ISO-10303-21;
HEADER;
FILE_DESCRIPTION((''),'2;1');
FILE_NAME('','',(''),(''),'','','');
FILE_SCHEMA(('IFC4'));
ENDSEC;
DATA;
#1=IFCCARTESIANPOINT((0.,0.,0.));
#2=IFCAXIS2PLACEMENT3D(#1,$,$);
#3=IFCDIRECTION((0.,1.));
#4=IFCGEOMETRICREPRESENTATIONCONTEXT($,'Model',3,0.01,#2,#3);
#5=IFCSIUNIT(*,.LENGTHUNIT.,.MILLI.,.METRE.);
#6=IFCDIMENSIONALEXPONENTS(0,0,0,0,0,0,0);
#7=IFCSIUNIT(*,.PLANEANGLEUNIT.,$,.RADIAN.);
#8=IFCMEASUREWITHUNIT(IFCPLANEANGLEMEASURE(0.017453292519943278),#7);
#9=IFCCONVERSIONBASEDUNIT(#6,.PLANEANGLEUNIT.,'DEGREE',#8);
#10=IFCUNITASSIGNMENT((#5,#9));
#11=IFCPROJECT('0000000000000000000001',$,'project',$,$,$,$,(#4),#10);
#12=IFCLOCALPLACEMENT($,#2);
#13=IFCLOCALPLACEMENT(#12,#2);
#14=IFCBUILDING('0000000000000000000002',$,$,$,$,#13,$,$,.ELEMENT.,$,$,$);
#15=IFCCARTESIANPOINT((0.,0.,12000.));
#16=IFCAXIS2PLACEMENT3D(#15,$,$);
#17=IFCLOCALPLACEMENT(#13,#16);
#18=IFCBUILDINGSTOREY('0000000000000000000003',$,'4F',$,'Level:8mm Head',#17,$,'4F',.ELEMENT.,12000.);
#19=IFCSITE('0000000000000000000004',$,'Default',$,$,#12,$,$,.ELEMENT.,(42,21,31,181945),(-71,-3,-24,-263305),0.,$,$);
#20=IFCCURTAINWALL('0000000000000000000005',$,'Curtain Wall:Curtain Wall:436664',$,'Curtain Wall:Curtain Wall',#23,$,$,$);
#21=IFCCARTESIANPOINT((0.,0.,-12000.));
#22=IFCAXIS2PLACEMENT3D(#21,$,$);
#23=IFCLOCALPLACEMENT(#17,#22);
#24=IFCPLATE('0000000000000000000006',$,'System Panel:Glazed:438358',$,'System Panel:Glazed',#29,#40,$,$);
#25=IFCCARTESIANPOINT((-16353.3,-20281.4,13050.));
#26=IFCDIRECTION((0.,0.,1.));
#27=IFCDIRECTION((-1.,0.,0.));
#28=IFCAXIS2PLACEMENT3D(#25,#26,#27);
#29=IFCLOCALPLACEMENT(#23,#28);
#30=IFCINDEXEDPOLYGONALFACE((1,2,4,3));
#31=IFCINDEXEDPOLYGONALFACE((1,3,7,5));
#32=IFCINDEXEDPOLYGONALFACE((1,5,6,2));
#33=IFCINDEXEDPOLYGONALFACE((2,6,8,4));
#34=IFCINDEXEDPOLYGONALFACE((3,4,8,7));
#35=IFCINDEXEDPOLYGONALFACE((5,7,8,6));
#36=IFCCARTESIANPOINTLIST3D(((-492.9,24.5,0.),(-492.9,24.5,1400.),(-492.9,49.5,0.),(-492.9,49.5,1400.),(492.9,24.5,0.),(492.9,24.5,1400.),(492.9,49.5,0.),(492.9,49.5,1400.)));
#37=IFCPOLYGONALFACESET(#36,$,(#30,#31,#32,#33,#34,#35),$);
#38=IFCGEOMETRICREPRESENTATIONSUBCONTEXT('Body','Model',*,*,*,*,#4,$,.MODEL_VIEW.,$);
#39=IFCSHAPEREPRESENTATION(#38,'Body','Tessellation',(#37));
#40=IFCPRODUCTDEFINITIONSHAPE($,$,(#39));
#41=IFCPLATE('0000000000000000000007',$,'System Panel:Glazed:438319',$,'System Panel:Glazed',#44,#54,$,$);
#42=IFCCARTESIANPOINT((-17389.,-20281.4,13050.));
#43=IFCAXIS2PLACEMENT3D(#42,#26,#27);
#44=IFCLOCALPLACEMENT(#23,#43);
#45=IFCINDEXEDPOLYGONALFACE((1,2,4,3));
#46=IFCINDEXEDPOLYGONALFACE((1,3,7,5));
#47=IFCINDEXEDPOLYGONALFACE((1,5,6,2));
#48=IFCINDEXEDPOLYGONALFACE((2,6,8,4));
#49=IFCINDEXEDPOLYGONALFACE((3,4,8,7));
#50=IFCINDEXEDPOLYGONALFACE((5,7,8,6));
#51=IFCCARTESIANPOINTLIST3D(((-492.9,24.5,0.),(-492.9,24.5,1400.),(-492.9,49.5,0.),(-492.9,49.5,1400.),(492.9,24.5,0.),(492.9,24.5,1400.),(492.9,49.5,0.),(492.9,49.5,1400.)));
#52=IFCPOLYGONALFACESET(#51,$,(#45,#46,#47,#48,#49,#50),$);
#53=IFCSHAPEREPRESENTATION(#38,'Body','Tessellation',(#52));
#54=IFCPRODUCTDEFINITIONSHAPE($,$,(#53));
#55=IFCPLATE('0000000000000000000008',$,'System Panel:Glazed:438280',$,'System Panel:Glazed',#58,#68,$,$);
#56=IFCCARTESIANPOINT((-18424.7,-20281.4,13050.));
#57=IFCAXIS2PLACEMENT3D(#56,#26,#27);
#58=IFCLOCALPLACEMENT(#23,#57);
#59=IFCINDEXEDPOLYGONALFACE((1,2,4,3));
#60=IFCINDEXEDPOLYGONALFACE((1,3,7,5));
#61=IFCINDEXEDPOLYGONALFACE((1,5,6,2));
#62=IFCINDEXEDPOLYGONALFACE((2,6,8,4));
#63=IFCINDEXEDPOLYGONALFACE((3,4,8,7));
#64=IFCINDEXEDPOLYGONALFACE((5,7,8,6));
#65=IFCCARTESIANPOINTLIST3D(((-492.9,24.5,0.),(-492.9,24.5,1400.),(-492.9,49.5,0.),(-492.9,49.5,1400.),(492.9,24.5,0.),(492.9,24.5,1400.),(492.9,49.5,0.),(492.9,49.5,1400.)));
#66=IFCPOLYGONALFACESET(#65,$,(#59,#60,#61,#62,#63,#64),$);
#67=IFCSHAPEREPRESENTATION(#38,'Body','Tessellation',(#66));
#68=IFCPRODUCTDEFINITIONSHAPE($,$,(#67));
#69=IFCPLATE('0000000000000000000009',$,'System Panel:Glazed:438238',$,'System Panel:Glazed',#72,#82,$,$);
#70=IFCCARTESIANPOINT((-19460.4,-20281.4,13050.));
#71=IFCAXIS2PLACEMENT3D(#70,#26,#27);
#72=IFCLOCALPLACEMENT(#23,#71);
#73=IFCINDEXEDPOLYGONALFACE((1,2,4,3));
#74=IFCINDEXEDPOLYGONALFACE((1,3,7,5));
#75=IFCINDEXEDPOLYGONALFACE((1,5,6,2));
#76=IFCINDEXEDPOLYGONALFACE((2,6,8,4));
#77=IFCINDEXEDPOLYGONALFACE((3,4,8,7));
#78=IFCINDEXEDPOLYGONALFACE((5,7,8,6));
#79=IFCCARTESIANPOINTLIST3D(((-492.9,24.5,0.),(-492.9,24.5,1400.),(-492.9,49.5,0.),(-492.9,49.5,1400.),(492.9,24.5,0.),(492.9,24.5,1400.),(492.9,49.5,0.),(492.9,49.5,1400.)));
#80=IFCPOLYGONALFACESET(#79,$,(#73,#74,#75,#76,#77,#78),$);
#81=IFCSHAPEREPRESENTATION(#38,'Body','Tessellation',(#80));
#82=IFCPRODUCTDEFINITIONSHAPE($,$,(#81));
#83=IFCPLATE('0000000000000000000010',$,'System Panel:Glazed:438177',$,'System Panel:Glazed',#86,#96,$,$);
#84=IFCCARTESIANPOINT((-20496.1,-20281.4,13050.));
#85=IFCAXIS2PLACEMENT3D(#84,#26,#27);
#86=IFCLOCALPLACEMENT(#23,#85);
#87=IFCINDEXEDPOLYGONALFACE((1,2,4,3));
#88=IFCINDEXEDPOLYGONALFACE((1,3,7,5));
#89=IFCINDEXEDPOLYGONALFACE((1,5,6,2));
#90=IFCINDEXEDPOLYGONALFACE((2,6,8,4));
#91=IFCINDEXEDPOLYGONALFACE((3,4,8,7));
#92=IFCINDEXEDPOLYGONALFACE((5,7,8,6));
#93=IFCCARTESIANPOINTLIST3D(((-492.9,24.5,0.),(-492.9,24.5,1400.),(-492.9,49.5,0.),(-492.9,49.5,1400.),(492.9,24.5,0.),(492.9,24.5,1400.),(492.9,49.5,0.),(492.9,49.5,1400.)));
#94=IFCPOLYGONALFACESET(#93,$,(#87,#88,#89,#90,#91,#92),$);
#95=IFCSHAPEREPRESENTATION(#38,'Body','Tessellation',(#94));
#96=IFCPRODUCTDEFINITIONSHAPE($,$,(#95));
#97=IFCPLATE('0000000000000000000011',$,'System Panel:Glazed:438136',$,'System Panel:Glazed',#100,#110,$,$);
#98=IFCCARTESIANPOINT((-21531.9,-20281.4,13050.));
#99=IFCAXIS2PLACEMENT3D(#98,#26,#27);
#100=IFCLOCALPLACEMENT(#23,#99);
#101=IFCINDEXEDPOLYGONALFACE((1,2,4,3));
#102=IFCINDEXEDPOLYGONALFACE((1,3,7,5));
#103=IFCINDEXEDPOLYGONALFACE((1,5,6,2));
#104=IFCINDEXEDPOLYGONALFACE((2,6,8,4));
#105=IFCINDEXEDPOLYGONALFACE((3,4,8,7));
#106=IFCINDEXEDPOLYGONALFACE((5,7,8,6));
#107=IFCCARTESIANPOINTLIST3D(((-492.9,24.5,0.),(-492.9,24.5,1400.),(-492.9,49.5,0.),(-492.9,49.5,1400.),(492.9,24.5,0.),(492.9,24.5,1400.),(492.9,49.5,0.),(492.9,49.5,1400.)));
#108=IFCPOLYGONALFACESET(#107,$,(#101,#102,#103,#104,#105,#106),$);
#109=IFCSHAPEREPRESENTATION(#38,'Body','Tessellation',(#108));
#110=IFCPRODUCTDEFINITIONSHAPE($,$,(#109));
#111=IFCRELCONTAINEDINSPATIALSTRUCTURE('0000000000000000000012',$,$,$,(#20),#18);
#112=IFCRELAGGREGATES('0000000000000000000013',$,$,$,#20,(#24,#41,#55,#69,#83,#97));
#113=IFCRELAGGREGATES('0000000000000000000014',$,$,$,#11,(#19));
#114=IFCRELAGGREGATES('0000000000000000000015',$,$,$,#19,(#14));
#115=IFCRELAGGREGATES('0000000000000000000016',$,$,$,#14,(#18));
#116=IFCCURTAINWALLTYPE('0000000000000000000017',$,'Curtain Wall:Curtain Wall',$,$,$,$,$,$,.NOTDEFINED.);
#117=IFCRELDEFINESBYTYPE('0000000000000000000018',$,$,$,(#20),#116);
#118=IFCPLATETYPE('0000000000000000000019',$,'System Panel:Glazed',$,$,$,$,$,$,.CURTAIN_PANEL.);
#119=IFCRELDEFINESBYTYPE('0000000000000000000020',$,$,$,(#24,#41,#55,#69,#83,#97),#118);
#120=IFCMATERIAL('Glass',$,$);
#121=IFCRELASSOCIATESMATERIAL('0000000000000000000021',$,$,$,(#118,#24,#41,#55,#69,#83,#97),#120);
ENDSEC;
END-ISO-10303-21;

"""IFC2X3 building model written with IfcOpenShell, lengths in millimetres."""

from ifc_helpers import new_model, entity, si_unit, converted_unit, direction, frame, origin, origin_2d_with_axis, place, context, subcontext, project, spatial, rectangle, extrude, source, transform, mapped, material, type_object, type_shapes, element, aggregate, save


model = new_model("IFC2X3")

# Units and contexts
model_context = context("Model", 3, precision=0.01, world=origin(), true_north=direction((0.0, 1.0)))
body_context = subcontext(model_context, "Body", "Model", "MODEL_VIEW")
ifc_project = project(units=[si_unit("LENGTHUNIT", "METRE", prefix="MILLI"), converted_unit("PLANEANGLEUNIT", "DEGREE", entity("IfcPlaneAngleMeasure", 0.017453292519943278), si_unit("PLANEANGLEUNIT", "RADIAN"), dimensions=[0, 0, 0, 0, 0, 0, 0])], contexts=[model_context])

# Site, building, storey
site_placement = place(None, origin())
site = spatial("IfcSite", under=ifc_project, at=site_placement, Name="Default", CompositionType="ELEMENT", RefLatitude=(42, 21, 31, 181945), RefLongitude=(-71, -3, -24, -263305), RefElevation=0.0)
building_placement = place(site_placement, origin())
building = spatial("IfcBuilding", under=site, at=building_placement, CompositionType="ELEMENT")
storey_placement = place(building_placement, frame((0.0, 0.0, 12000.0)))
storey = spatial("IfcBuildingStorey", under=building, at=storey_placement, Name="4F", ObjectType="Level:8mm Head", LongName="4F", CompositionType="ELEMENT", Elevation=12000.0)

# Curtain wall
curtain_wall_type = type_object("IfcCurtainWallType", Name="Curtain Wall:Curtain Wall", PredefinedType="NOTDEFINED")
curtain_wall_placement = place(storey_placement, frame((0.0, 0.0, -12000.0)))
curtain_wall = element("IfcCurtainWall", 1, at=curtain_wall_placement, inside=storey, type_object=curtain_wall_type, Name="Curtain Wall:Curtain Wall:436664", ObjectType="Curtain Wall:Curtain Wall")

# Plates
ifc_material_1 = material(Name="Glass")
plate_type = type_object("IfcPlateType", Name="System Panel:Glazed", PredefinedType="CURTAIN_PANEL", material=ifc_material_1)
shared_shape_1 = source(origin(), body_context, "Body", "SweptSolid", [
    extrude(rectangle(XDim=25.0, YDim=985.7, at=origin_2d_with_axis()), frame((0.0, 37.0, 0.0), z_axis=(0.0, 0.0, 1.0), x_axis=(0.0, 1.0, 0.0)), (0.0, 0.0, 1.0), 1400.0),
])
type_shapes(plate_type, [shared_shape_1])
plate_1_placement = place(curtain_wall_placement, frame((-16353.3, -20281.4, 13050.0), z_axis=(0.0, 0.0, 1.0), x_axis=(-1.0, 0.0, 0.0)))
plate_1 = element("IfcPlate", 2, at=plate_1_placement, type_object=plate_type, material=ifc_material_1, Name="System Panel:Glazed:438358", ObjectType="System Panel:Glazed", context=body_context, shape_type="MappedRepresentation", body=[
    mapped(shared_shape_1, transform((0.0, 0.0, 0.0), scale=1.0)),
])
plate_2_placement = place(curtain_wall_placement, frame((-17389.0, -20281.4, 13050.0), z_axis=(0.0, 0.0, 1.0), x_axis=(-1.0, 0.0, 0.0)))
plate_2 = element("IfcPlate", 3, at=plate_2_placement, type_object=plate_type, material=ifc_material_1, Name="System Panel:Glazed:438319", ObjectType="System Panel:Glazed", context=body_context, shape_type="MappedRepresentation", body=[
    mapped(shared_shape_1, transform((0.0, 0.0, 0.0), scale=1.0)),
])
plate_3_placement = place(curtain_wall_placement, frame((-18424.7, -20281.4, 13050.0), z_axis=(0.0, 0.0, 1.0), x_axis=(-1.0, 0.0, 0.0)))
plate_3 = element("IfcPlate", 4, at=plate_3_placement, type_object=plate_type, material=ifc_material_1, Name="System Panel:Glazed:438280", ObjectType="System Panel:Glazed", context=body_context, shape_type="MappedRepresentation", body=[
    mapped(shared_shape_1, transform((0.0, 0.0, 0.0), scale=1.0)),
])
plate_4_placement = place(curtain_wall_placement, frame((-19460.4, -20281.4, 13050.0), z_axis=(0.0, 0.0, 1.0), x_axis=(-1.0, 0.0, 0.0)))
plate_4 = element("IfcPlate", 5, at=plate_4_placement, type_object=plate_type, material=ifc_material_1, Name="System Panel:Glazed:438238", ObjectType="System Panel:Glazed", context=body_context, shape_type="MappedRepresentation", body=[
    mapped(shared_shape_1, transform((0.0, 0.0, 0.0), scale=1.0)),
])
plate_5_placement = place(curtain_wall_placement, frame((-20496.1, -20281.4, 13050.0), z_axis=(0.0, 0.0, 1.0), x_axis=(-1.0, 0.0, 0.0)))
plate_5 = element("IfcPlate", 6, at=plate_5_placement, type_object=plate_type, material=ifc_material_1, Name="System Panel:Glazed:438177", ObjectType="System Panel:Glazed", context=body_context, shape_type="MappedRepresentation", body=[
    mapped(shared_shape_1, transform((0.0, 0.0, 0.0), scale=1.0)),
])
plate_6_placement = place(curtain_wall_placement, frame((-21531.9, -20281.4, 13050.0), z_axis=(0.0, 0.0, 1.0), x_axis=(-1.0, 0.0, 0.0)))
plate_6 = element("IfcPlate", 7, at=plate_6_placement, type_object=plate_type, material=ifc_material_1, Name="System Panel:Glazed:438136", ObjectType="System Panel:Glazed", context=body_context, shape_type="MappedRepresentation", body=[
    mapped(shared_shape_1, transform((0.0, 0.0, 0.0), scale=1.0)),
])
aggregate(curtain_wall, [plate_1, plate_2, plate_3, plate_4, plate_5, plate_6])

save(model, "model.ifc")
